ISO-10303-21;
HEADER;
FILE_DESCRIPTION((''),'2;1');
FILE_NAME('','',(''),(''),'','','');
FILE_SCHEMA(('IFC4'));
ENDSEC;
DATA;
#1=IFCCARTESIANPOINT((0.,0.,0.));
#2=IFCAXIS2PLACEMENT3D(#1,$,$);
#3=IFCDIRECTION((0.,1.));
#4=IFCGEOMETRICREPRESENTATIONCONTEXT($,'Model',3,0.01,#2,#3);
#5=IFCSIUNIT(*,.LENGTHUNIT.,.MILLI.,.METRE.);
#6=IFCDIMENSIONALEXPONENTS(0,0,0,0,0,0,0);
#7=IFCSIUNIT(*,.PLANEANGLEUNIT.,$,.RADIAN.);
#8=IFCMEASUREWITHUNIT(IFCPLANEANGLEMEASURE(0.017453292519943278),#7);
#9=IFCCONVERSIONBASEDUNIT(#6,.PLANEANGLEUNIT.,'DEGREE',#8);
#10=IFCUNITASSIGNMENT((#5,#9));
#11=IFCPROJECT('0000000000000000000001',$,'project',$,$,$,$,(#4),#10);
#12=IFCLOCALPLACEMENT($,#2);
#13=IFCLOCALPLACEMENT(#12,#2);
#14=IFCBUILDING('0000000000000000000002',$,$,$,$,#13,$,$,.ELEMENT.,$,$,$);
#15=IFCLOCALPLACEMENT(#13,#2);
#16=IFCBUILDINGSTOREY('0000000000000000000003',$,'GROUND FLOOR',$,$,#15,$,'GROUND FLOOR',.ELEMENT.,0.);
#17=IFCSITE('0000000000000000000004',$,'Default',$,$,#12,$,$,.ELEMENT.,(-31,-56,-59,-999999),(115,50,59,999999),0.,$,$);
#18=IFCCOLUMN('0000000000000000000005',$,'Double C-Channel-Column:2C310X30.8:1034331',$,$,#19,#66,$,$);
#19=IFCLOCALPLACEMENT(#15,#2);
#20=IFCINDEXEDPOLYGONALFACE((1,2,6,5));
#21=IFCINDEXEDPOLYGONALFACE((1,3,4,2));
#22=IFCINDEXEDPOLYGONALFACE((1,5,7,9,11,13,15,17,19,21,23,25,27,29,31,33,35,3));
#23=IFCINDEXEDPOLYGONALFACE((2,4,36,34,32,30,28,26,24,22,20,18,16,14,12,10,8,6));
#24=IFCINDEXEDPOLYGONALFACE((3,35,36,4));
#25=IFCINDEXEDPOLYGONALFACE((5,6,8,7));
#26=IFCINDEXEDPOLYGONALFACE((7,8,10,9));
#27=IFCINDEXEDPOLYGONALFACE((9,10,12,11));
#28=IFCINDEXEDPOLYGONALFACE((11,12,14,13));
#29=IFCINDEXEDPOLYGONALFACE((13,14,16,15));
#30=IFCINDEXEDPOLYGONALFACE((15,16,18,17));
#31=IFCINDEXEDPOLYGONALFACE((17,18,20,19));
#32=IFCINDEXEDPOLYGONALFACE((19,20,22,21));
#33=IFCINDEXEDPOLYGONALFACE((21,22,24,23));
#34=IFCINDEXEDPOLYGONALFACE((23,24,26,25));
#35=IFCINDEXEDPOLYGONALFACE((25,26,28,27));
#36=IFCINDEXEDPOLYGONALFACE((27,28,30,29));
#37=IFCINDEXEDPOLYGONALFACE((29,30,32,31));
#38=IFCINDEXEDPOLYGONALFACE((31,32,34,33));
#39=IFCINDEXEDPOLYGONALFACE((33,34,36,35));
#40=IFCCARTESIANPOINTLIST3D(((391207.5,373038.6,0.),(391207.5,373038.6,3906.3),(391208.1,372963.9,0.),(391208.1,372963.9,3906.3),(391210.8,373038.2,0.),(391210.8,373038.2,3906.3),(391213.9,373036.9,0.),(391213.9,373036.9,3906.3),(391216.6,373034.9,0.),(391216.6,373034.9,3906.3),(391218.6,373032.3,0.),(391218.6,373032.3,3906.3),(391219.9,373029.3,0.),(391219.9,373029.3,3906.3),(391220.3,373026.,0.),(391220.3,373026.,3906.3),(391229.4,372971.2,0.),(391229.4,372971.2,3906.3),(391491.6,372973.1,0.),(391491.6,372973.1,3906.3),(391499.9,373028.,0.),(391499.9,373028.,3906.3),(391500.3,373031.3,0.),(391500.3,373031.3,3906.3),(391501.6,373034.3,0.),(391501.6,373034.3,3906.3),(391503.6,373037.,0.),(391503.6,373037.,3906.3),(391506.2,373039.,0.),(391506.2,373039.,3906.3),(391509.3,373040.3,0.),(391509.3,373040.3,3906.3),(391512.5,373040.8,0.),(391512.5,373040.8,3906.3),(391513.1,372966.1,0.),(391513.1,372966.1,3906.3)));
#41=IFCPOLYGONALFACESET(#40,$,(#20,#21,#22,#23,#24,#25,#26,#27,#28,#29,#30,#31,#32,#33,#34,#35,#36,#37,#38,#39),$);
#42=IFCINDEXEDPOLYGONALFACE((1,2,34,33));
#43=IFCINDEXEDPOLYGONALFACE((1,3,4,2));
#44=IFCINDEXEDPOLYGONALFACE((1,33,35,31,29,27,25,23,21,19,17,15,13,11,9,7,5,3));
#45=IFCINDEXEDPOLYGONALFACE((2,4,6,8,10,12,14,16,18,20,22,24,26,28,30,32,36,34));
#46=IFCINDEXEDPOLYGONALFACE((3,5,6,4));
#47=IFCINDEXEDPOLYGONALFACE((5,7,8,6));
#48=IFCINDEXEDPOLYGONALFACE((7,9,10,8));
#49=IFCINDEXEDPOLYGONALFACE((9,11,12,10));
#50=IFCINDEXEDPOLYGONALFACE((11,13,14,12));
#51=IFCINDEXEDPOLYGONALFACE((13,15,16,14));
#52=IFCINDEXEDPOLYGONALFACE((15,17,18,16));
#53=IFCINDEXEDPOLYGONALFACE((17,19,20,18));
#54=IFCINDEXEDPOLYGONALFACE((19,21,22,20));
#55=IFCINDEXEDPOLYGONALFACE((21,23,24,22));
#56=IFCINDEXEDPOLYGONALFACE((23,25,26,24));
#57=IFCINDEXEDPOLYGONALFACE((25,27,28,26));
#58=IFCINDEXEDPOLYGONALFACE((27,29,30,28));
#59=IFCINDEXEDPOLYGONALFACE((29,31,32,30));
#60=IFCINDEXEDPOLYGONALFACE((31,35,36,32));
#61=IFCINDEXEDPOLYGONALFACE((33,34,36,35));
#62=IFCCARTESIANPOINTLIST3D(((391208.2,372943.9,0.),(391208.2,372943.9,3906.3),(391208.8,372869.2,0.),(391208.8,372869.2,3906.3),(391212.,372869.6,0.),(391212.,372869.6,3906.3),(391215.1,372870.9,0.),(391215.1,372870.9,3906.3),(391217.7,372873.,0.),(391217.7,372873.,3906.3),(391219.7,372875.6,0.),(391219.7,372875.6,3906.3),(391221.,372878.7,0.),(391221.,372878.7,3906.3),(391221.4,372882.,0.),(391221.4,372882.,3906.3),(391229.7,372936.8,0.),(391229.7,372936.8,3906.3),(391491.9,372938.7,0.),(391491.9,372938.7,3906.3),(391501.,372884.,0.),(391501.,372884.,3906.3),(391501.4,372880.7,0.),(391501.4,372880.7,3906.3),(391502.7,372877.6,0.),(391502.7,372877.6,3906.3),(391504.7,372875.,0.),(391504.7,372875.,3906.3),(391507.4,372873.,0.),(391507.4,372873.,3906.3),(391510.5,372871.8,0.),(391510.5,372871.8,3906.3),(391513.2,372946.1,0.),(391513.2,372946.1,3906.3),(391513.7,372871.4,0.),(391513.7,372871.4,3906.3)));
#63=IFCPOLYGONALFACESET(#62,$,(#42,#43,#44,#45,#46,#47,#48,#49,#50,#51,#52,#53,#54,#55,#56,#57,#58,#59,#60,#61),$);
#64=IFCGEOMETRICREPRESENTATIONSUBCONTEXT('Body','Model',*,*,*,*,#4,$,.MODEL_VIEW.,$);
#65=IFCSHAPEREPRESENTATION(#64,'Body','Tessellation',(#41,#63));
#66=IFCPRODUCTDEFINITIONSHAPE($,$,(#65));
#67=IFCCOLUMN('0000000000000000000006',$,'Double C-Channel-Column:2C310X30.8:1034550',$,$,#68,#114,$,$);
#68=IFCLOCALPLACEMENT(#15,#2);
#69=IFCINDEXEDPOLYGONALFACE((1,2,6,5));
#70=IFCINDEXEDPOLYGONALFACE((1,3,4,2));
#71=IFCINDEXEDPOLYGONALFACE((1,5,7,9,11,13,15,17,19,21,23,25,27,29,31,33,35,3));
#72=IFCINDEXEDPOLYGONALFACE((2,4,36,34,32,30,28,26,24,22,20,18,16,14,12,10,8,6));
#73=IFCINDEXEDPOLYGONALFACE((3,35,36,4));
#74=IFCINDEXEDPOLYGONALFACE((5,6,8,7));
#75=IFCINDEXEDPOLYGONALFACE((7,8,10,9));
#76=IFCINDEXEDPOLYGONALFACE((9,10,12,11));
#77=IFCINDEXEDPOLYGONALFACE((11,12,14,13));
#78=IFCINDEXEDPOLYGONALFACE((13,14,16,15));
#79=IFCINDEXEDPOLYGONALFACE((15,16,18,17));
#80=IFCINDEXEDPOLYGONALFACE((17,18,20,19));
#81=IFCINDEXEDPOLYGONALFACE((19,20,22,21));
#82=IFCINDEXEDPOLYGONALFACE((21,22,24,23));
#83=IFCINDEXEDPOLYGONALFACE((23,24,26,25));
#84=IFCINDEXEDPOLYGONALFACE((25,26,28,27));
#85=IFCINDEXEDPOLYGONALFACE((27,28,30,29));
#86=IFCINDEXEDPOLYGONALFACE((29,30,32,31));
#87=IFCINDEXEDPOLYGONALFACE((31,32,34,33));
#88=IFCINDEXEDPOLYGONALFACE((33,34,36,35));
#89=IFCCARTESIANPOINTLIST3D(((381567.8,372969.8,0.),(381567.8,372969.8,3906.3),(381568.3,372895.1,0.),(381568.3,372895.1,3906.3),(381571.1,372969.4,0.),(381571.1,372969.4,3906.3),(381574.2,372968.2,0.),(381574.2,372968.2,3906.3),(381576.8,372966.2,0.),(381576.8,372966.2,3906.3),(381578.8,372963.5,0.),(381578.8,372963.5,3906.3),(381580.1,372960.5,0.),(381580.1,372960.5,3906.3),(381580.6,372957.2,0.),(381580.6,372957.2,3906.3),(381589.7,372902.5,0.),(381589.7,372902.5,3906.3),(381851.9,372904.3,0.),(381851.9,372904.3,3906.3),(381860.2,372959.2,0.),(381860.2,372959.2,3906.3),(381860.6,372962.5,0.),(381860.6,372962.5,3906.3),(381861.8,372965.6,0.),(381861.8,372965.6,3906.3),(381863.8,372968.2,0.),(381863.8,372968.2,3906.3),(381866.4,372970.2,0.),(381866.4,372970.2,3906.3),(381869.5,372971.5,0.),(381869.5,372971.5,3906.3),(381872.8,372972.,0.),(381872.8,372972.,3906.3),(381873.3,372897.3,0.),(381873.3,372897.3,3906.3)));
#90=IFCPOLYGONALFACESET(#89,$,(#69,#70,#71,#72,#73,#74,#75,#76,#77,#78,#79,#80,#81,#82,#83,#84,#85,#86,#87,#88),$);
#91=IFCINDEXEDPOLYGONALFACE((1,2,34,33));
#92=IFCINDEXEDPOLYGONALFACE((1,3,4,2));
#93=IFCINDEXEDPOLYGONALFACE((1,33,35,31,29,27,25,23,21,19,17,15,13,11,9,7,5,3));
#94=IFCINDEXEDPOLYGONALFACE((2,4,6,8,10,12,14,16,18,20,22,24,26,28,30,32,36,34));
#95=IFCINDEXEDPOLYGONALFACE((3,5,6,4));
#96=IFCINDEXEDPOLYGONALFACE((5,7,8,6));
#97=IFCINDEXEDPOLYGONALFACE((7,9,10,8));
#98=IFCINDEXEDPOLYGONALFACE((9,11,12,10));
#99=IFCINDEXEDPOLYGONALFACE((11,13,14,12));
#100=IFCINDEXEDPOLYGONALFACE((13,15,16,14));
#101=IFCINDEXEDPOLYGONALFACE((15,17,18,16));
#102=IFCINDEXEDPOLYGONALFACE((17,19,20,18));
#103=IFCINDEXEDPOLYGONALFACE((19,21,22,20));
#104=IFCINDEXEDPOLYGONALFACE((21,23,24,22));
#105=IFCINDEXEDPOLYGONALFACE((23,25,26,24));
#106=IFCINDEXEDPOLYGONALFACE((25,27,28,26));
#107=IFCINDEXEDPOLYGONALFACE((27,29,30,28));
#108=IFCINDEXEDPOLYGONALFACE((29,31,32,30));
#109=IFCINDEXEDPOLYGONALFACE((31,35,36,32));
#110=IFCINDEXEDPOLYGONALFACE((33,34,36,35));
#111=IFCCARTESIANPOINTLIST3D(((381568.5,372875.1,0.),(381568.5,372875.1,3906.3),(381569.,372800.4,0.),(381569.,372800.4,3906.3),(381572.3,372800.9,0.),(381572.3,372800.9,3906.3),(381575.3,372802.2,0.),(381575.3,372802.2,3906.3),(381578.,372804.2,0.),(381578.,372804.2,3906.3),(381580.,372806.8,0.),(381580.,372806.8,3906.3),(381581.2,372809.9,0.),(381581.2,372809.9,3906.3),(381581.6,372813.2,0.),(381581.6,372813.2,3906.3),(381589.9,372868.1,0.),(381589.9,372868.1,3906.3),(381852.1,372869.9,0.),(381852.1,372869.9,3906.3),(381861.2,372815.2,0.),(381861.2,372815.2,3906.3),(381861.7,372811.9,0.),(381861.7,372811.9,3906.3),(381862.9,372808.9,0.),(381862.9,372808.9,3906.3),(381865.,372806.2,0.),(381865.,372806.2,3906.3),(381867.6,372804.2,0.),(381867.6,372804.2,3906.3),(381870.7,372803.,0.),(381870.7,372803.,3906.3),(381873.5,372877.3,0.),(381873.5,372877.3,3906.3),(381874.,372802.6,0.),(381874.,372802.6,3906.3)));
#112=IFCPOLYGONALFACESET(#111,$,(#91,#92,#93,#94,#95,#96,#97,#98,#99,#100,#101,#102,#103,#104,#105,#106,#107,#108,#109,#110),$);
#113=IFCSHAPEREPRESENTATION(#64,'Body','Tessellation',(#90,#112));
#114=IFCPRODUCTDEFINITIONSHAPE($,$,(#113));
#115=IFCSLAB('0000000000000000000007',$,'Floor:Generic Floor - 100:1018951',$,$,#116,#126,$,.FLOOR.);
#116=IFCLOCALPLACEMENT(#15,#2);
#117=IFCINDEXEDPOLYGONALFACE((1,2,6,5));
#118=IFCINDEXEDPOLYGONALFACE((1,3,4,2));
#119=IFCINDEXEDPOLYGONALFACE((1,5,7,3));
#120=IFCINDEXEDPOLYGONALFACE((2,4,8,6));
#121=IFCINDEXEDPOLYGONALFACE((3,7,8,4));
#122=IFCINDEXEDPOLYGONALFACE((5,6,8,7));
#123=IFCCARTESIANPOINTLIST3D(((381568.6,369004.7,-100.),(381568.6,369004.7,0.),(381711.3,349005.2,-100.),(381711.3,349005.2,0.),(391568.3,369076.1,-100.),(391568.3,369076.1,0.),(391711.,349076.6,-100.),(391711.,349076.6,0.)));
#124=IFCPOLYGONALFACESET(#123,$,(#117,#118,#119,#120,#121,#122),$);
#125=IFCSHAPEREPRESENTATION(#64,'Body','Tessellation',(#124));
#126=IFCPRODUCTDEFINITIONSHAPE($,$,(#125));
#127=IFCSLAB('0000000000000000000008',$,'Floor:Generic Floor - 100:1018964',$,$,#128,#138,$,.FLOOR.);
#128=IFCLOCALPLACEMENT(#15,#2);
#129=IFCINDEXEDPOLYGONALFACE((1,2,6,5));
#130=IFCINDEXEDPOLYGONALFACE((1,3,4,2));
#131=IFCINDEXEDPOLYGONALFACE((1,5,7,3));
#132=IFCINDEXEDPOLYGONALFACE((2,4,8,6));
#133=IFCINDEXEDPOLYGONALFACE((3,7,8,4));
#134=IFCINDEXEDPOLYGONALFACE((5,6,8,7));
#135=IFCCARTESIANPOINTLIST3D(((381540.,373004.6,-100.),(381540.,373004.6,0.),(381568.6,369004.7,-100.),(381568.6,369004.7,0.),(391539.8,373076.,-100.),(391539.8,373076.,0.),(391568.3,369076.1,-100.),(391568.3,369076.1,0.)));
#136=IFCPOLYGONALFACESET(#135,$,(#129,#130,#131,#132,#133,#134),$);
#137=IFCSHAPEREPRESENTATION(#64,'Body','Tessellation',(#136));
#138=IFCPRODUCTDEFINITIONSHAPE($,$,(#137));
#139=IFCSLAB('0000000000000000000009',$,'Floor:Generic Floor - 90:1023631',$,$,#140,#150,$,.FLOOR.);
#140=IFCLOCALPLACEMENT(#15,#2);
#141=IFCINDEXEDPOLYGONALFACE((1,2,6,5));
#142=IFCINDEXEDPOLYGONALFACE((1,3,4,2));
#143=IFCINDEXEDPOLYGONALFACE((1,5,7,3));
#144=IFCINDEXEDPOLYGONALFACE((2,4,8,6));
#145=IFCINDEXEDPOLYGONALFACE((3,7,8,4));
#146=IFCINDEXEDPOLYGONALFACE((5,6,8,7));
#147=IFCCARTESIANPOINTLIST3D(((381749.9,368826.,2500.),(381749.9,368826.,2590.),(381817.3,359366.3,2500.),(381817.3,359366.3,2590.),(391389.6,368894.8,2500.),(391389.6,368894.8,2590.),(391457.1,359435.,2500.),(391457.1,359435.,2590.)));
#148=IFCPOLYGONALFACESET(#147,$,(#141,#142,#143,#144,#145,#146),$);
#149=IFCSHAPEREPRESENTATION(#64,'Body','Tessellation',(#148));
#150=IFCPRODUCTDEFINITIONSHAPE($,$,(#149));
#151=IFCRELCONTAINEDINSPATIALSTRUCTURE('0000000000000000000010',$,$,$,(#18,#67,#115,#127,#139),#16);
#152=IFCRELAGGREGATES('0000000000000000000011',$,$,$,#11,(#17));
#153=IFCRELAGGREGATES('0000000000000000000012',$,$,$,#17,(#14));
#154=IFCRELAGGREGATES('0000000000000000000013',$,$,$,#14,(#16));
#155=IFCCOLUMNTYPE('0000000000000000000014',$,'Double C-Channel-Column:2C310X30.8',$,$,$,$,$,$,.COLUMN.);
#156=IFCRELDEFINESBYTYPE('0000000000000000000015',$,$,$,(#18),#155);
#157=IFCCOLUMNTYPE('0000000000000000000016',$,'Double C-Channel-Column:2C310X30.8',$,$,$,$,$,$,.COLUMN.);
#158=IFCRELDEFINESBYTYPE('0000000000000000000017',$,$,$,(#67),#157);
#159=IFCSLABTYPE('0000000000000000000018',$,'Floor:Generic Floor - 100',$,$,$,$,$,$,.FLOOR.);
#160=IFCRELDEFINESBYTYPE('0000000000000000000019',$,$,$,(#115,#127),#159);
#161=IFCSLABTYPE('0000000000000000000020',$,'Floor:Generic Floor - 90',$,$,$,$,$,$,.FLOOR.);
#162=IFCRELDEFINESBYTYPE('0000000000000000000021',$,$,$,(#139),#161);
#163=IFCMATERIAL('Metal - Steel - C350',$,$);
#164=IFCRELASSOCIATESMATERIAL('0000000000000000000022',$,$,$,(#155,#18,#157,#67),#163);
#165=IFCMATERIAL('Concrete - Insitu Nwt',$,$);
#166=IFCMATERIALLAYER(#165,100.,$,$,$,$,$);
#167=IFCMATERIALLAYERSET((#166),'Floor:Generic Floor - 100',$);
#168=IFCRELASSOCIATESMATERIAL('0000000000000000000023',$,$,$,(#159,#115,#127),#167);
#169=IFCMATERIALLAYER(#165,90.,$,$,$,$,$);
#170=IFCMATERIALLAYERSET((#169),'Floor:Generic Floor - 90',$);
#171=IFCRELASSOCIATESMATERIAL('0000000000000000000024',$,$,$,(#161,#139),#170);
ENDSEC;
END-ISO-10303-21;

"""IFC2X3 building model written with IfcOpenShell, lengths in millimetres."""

from ifc_helpers import new_model, entity, si_unit, converted_unit, direction, frame, frame_2d, origin, place, context, subcontext, project, spatial, polyline, circle_curve, parameter, trimmed, segment, composite_curve, rectangle, outline, extrude, source, transform, mapped, material, layer, layer_set, layer_usage, type_object, type_shapes, element, save


model = new_model("IFC2X3")

# Units and contexts
model_context = context("Model", 3, precision=0.01, world=origin(), true_north=direction((0.0, 1.0)))
body_context = subcontext(model_context, "Body", "Model", "MODEL_VIEW")
ifc_project = project(units=[si_unit("LENGTHUNIT", "METRE", prefix="MILLI"), converted_unit("PLANEANGLEUNIT", "DEGREE", entity("IfcPlaneAngleMeasure", 0.017453292519943278), si_unit("PLANEANGLEUNIT", "RADIAN"), dimensions=[0, 0, 0, 0, 0, 0, 0])], contexts=[model_context])

# Site, building, storey
site_placement = place(None, origin())
site = spatial("IfcSite", under=ifc_project, at=site_placement, Name="Default", CompositionType="ELEMENT", RefLatitude=(-31, -56, -59, -999999), RefLongitude=(115, 50, 59, 999999), RefElevation=0.0)
building_placement = place(site_placement, origin())
building = spatial("IfcBuilding", under=site, at=building_placement, CompositionType="ELEMENT")
storey_placement = place(building_placement, origin())
storey = spatial("IfcBuildingStorey", under=building, at=storey_placement, Name="GROUND FLOOR", LongName="GROUND FLOOR", CompositionType="ELEMENT", Elevation=0.0)

# Columns
ifc_material_1 = material(Name="Metal - Steel - C350")
column_type_1 = type_object("IfcColumnType", Name="Double C-Channel-Column:2C310X30.8", PredefinedType="COLUMN", material=ifc_material_1)
shared_shape_1 = source(origin(), body_context, "Body", "SweptSolid", [
    extrude(outline(composite_curve([segment(polyline([(-36.0, -152.5), (38.7, -152.5)]), True, "CONTINUOUS"), segment(trimmed(circle_curve(frame_2d((26.0, -152.5), x_axis=(1.0, 0.0)), 12.7), [parameter(360.0)], [parameter(90.0)], True, "PARAMETER"), True, "CONTINUOUS"), segment(polyline([(26.0, -139.8), (-28.8, -131.1)]), True, "CONTINUOUS"), segment(polyline([(-28.8, -131.1), (-28.8, 131.1)]), True, "CONTINUOUS"), segment(polyline([(-28.8, 131.1), (26.0, 139.8)]), True, "CONTINUOUS"), segment(trimmed(circle_curve(frame_2d((26.0, 152.5), x_axis=(1.0, 0.0)), 12.7), [parameter(270.0)], [parameter(0.0)], True, "PARAMETER"), True, "CONTINUOUS"), segment(polyline([(38.7, 152.5), (-36.0, 152.5)]), True, "CONTINUOUS"), segment(polyline([(-36.0, 152.5), (-36.0, -152.5)]), True, "CONTINUOUS")], self_intersect=False)), frame((391360.3, 373000.9, 0.0), z_axis=(0.0, 0.0, 1.0), x_axis=(-0.007134, 0.999975, 0.0)), (0.0, 0.0, 1.0), 3906.3),
    extrude(outline(composite_curve([segment(polyline([(-152.5, -36.0), (152.5, -36.0)]), True, "CONTINUOUS"), segment(polyline([(152.5, -36.0), (152.5, 38.7)]), True, "CONTINUOUS"), segment(trimmed(circle_curve(frame_2d((152.5, 26.0), x_axis=(0.0, 1.0)), 12.7), [parameter(360.0)], [parameter(90.0)], True, "PARAMETER"), True, "CONTINUOUS"), segment(polyline([(139.8, 26.0), (131.1, -28.8)]), True, "CONTINUOUS"), segment(polyline([(131.1, -28.8), (-131.1, -28.8)]), True, "CONTINUOUS"), segment(polyline([(-131.1, -28.8), (-139.8, 26.0)]), True, "CONTINUOUS"), segment(trimmed(circle_curve(frame_2d((-152.5, 26.0), x_axis=(0.0, 1.0)), 12.7), [parameter(270.0)], [parameter(0.0)], True, "PARAMETER"), True, "CONTINUOUS"), segment(polyline([(-152.5, 38.7), (-152.5, -36.0)]), True, "CONTINUOUS")], self_intersect=False)), frame((391361.0, 372909.0, 0.0), z_axis=(0.0, 0.0, 1.0), x_axis=(-0.999975, -0.007134, 0.0)), (0.0, 0.0, 1.0), 3906.3),
])
type_shapes(column_type_1, [shared_shape_1])
column_1_placement = place(storey_placement, origin())
element("IfcColumn", 1, at=column_1_placement, inside=storey, type_object=column_type_1, material=ifc_material_1, Name="Double C-Channel-Column:2C310X30.8:1034331", context=body_context, shape_type="MappedRepresentation", body=[
    mapped(shared_shape_1, transform((0.0, 0.0, 0.0), scale=1.0)),
])
column_type_2 = type_object("IfcColumnType", Name="Double C-Channel-Column:2C310X30.8", PredefinedType="COLUMN", material=ifc_material_1)
shared_shape_2 = source(origin(), body_context, "Body", "SweptSolid", [
    extrude(outline(composite_curve([segment(polyline([(-152.5, -36.0), (152.5, -36.0)]), True, "CONTINUOUS"), segment(polyline([(152.5, -36.0), (152.5, 38.7)]), True, "CONTINUOUS"), segment(trimmed(circle_curve(frame_2d((152.5, 26.0), x_axis=(0.0, 1.0)), 12.7), [parameter(0.0)], [parameter(90.0)], True, "PARAMETER"), True, "CONTINUOUS"), segment(polyline([(139.8, 26.0), (131.1, -28.8)]), True, "CONTINUOUS"), segment(polyline([(131.1, -28.8), (-131.1, -28.8)]), True, "CONTINUOUS"), segment(polyline([(-131.1, -28.8), (-139.8, 26.0)]), True, "CONTINUOUS"), segment(trimmed(circle_curve(frame_2d((-152.5, 26.0), x_axis=(0.0, 1.0)), 12.7), [parameter(270.0)], [parameter(0.0)], True, "PARAMETER"), True, "CONTINUOUS"), segment(polyline([(-152.5, 38.7), (-152.5, -36.0)]), True, "CONTINUOUS")], self_intersect=False)), frame((381720.6, 372932.2, 0.0), z_axis=(0.0, 0.0, 1.0), x_axis=(0.999975, 0.007134, 0.0)), (0.0, 0.0, 1.0), 3906.3),
    extrude(outline(composite_curve([segment(polyline([(-36.0, -152.5), (38.7, -152.5)]), True, "CONTINUOUS"), segment(trimmed(circle_curve(frame_2d((26.0, -152.5), x_axis=(1.0, 0.0)), 12.7), [parameter(360.0)], [parameter(90.0)], True, "PARAMETER"), True, "CONTINUOUS"), segment(polyline([(26.0, -139.8), (-28.8, -131.1)]), True, "CONTINUOUS"), segment(polyline([(-28.8, -131.1), (-28.8, 131.1)]), True, "CONTINUOUS"), segment(polyline([(-28.8, 131.1), (26.0, 139.8)]), True, "CONTINUOUS"), segment(trimmed(circle_curve(frame_2d((26.0, 152.5), x_axis=(1.0, 0.0)), 12.7), [parameter(270.0)], [parameter(0.0)], True, "PARAMETER"), True, "CONTINUOUS"), segment(polyline([(38.7, 152.5), (-36.0, 152.5)]), True, "CONTINUOUS"), segment(polyline([(-36.0, 152.5), (-36.0, -152.5)]), True, "CONTINUOUS")], self_intersect=False)), frame((381721.2, 372840.2, 0.0), z_axis=(0.0, 0.0, 1.0), x_axis=(0.007134, -0.999975, 0.0)), (0.0, 0.0, 1.0), 3906.3),
])
type_shapes(column_type_2, [shared_shape_2])
column_2_placement = place(storey_placement, origin())
element("IfcColumn", 2, at=column_2_placement, inside=storey, type_object=column_type_2, material=ifc_material_1, Name="Double C-Channel-Column:2C310X30.8:1034550", context=body_context, shape_type="MappedRepresentation", body=[
    mapped(shared_shape_2, transform((0.0, 0.0, 0.0), scale=1.0)),
])

# Slabs
ifc_material_2 = material(Name="Concrete - Insitu Nwt")
ifc_layer_1 = layer(ifc_material_2, 100.0)
ifc_layer_set_1 = layer_set([ifc_layer_1], Name="Floor:Generic Floor - 100")
ifc_layer_usage_1 = layer_usage(ifc_layer_set_1, "AXIS3", "POSITIVE", 0.0)
slab_type_1 = type_object("IfcSlabType", Name="Floor:Generic Floor - 100", PredefinedType="FLOOR", material=ifc_layer_set_1)
slab_1_placement = place(storey_placement, origin())
element("IfcSlab", 3, at=slab_1_placement, inside=storey, type_object=slab_type_1, material=ifc_layer_usage_1, Name="Floor:Generic Floor - 100:1018951", PredefinedType="FLOOR", context=body_context, shape_type="SweptSolid", body=[
    extrude(rectangle(XDim=20000.0, YDim=10000.0, at=frame_2d((0.0, 0.0), x_axis=(1.0, 0.0))), frame((386639.8, 359040.7, 0.0), z_axis=(0.0, 0.0, -1.0), x_axis=(0.007134, -0.999975, 0.0)), (0.0, 0.0, 1.0), 100.0),
])
ifc_layer_usage_2 = layer_usage(ifc_layer_set_1, "AXIS3", "POSITIVE", 0.0)
slab_2_placement = place(storey_placement, origin())
element("IfcSlab", 4, at=slab_2_placement, inside=storey, type_object=slab_type_1, material=ifc_layer_usage_2, Name="Floor:Generic Floor - 100:1018964", PredefinedType="FLOOR", context=body_context, shape_type="SweptSolid", body=[
    extrude(rectangle(XDim=4000.0, YDim=10000.0, at=frame_2d((0.0, 0.0), x_axis=(1.0, 0.0))), frame((386554.2, 371040.4, 0.0), z_axis=(0.0, 0.0, -1.0), x_axis=(0.007134, -0.999975, 0.0)), (0.0, 0.0, 1.0), 100.0),
])
ifc_layer_2 = layer(ifc_material_2, 90.0)
ifc_layer_set_2 = layer_set([ifc_layer_2], Name="Floor:Generic Floor - 90")
ifc_layer_usage_3 = layer_usage(ifc_layer_set_2, "AXIS3", "POSITIVE", 0.0)
slab_type_2 = type_object("IfcSlabType", Name="Floor:Generic Floor - 90", PredefinedType="FLOOR", material=ifc_layer_set_2)
slab_3_placement = place(storey_placement, origin())
element("IfcSlab", 5, at=slab_3_placement, inside=storey, type_object=slab_type_2, material=ifc_layer_usage_3, Name="Floor:Generic Floor - 90:1023631", PredefinedType="FLOOR", context=body_context, shape_type="SweptSolid", body=[
    extrude(rectangle(XDim=9460.0, YDim=9640.0, at=frame_2d((0.0, 0.0), x_axis=(1.0, 0.0))), frame((386603.5, 364130.5, 2590.0), z_axis=(0.0, 0.0, -1.0), x_axis=(0.007134, -0.999975, 0.0)), (0.0, 0.0, 1.0), 90.0),
])

save(model, "model.ifc")
